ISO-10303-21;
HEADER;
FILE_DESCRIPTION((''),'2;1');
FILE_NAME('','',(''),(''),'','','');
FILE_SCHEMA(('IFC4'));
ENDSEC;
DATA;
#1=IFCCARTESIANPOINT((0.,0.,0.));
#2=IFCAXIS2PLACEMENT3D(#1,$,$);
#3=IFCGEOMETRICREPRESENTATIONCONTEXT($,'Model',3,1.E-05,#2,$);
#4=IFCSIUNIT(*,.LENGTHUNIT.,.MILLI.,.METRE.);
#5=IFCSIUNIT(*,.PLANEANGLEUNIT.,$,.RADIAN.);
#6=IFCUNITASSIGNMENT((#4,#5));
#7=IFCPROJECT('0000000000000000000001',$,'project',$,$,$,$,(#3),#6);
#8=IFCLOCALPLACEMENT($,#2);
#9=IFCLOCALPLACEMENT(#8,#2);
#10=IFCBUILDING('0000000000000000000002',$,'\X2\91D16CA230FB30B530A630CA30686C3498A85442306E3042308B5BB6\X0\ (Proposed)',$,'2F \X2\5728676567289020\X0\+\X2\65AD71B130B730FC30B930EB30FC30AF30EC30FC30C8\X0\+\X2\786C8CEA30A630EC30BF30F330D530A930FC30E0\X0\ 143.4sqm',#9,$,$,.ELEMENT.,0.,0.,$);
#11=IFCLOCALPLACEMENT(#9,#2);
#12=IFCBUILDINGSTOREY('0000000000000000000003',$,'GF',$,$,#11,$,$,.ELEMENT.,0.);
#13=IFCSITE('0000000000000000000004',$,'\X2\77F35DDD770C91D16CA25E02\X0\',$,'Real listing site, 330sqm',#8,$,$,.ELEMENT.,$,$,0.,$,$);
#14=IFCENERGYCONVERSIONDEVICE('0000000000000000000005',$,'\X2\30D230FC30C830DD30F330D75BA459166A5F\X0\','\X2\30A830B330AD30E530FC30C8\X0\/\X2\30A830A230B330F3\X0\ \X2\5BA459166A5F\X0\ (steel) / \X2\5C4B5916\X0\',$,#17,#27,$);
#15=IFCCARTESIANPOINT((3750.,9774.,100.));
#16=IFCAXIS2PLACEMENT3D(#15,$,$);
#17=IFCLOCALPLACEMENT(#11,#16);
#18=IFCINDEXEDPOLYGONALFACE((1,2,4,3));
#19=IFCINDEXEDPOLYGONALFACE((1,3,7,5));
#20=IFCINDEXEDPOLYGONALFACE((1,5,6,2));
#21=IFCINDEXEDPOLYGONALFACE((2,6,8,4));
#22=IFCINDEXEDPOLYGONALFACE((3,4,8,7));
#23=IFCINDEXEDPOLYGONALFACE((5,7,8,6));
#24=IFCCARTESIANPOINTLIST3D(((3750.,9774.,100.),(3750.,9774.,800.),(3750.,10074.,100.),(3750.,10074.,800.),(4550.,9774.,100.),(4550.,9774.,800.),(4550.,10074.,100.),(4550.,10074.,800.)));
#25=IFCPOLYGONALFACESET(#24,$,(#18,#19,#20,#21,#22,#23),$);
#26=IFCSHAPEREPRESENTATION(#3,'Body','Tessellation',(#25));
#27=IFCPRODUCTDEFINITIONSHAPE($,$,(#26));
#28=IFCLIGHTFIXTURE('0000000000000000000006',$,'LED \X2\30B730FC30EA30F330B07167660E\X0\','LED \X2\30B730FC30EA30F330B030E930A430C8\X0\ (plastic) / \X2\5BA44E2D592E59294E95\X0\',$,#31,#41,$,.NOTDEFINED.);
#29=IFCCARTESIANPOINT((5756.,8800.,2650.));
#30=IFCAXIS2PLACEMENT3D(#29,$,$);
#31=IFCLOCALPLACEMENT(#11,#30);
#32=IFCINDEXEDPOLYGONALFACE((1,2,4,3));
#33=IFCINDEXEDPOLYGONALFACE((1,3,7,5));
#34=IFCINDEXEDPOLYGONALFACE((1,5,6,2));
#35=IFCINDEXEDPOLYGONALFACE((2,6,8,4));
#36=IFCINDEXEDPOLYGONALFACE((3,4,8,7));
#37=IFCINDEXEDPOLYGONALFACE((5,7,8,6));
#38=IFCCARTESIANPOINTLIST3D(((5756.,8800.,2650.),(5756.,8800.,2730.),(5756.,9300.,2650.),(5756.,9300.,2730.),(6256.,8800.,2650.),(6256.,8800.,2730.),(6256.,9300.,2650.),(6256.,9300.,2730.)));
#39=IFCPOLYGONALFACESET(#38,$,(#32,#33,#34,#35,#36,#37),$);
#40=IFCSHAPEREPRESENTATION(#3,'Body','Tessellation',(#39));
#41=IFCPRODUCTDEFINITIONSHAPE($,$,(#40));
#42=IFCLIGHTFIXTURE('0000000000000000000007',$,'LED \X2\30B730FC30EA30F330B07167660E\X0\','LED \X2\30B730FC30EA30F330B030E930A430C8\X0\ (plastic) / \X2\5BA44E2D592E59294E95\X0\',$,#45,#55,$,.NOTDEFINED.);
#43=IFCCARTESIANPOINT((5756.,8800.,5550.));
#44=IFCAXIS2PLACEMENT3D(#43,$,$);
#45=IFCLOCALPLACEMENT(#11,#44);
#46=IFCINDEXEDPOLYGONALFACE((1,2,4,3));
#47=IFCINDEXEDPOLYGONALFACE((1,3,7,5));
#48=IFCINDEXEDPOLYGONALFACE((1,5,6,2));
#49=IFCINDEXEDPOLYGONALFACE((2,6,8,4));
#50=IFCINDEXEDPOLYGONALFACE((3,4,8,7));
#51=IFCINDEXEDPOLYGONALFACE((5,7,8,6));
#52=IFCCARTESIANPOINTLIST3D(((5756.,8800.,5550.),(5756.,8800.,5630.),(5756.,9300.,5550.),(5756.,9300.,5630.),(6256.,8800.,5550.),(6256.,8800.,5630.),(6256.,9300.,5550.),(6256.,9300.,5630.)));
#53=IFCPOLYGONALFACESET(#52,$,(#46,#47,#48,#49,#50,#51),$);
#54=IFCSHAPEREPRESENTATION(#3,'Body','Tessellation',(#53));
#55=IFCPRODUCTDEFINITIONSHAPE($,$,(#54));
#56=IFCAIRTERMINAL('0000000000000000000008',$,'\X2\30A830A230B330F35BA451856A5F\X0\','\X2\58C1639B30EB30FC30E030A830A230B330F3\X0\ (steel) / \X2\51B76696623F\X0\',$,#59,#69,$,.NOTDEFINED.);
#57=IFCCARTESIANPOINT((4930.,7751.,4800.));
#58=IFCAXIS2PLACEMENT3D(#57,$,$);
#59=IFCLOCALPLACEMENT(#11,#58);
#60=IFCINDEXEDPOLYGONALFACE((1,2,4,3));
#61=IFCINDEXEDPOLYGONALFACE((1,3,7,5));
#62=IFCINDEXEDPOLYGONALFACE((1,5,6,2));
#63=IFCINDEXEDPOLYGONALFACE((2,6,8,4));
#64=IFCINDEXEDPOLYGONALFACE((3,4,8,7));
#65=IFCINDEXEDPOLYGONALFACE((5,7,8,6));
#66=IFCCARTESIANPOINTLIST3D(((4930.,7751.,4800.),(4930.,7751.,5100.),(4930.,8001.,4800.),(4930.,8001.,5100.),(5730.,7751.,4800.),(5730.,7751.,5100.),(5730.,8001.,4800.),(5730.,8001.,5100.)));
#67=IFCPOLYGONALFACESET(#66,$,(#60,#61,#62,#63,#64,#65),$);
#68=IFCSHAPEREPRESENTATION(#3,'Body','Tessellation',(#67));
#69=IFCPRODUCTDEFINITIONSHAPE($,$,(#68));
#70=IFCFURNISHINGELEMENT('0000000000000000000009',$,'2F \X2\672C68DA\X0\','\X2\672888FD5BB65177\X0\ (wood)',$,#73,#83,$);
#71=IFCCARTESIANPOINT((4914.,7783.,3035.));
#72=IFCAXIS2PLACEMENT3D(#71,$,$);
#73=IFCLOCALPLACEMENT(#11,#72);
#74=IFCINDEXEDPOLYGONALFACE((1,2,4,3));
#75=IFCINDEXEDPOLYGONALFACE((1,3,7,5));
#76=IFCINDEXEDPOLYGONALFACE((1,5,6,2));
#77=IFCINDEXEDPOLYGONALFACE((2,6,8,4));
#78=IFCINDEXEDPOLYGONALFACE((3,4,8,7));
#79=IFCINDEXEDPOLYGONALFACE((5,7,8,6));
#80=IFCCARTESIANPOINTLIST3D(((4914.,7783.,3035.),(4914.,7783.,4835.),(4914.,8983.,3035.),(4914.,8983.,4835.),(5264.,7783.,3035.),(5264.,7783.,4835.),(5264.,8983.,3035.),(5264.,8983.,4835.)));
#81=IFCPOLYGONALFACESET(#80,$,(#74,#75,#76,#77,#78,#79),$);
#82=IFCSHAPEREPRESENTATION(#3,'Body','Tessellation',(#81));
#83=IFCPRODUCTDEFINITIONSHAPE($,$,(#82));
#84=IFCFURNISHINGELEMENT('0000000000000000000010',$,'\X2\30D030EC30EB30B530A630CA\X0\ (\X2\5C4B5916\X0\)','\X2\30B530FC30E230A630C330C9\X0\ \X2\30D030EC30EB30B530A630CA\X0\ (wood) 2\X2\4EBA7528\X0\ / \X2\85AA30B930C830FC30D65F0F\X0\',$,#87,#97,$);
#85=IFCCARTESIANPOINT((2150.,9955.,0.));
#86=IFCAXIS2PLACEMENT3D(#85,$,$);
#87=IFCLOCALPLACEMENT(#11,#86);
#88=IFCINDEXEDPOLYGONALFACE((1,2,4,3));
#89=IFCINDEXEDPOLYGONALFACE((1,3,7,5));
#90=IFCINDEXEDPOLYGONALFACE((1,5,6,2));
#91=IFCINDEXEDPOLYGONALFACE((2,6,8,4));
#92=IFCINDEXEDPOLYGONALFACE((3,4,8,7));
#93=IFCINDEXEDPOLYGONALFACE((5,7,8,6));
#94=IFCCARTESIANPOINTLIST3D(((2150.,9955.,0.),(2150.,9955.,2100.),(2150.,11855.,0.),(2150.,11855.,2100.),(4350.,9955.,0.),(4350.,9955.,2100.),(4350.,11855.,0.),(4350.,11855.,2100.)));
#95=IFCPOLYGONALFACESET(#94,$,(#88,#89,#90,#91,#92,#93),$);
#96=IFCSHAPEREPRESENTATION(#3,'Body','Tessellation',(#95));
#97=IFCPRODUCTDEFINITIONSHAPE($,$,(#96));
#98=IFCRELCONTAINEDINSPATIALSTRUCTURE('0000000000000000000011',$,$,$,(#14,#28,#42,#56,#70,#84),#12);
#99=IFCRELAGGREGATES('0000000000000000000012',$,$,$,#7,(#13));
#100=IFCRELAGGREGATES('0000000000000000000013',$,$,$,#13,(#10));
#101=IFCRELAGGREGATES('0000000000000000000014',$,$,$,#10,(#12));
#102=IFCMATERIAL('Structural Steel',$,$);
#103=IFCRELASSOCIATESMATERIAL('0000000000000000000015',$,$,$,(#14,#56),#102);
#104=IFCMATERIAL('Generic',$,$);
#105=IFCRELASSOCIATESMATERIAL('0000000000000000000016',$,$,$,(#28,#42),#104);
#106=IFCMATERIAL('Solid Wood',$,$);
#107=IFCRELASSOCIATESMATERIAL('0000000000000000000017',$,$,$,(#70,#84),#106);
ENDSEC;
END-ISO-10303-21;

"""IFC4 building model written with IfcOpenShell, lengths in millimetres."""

from ifc_helpers import new_model, si_unit, frame, frame_2d, origin, place, context, project, spatial, rectangle, extrude, material, element, save


model = new_model("IFC4")

# Units and contexts
model_context = context("Model", 3, precision=1e-05, world=origin())
ifc_project = project(units=[si_unit("LENGTHUNIT", "METRE", prefix="MILLI"), si_unit("PLANEANGLEUNIT", "RADIAN")], contexts=[model_context])

# Site, building, storey
site_placement = place(None, origin())
site = spatial("IfcSite", under=ifc_project, at=site_placement, Name="石川県金沢市", ObjectType="Real listing site, 330sqm", CompositionType="ELEMENT", RefElevation=0.0)
building_placement = place(site_placement, origin())
building = spatial("IfcBuilding", under=site, at=building_placement, Name="金沢・サウナと水風呂のある家 (Proposed)", ObjectType="2F 在来木造+断熱シースルークレート+硬質ウレタンフォーム 143.4sqm", CompositionType="ELEMENT", ElevationOfRefHeight=0.0, ElevationOfTerrain=0.0)
storey_placement = place(building_placement, origin())
storey = spatial("IfcBuildingStorey", under=building, at=storey_placement, Name="GF", CompositionType="ELEMENT", Elevation=0.0)

# Shared definitions
ifc_material_1 = material(Name="Solid Wood")

# Shared definitions
ifc_material_2 = material(Name="Structural Steel")

# Shared definitions
ifc_material_3 = material(Name="Generic")

# Energy conversion device
energy_conversion_device_placement = place(storey_placement, frame((3750.0, 9774.0, 100.0)))
element("IfcEnergyConversionDevice", 1, at=energy_conversion_device_placement, inside=storey, material=ifc_material_2, Name="ヒートポンプ室外機", Description="エコキュート/エアコン 室外機 (steel) / 屋外", context=model_context, shape_type="SweptSolid", body=[
    extrude(rectangle(XDim=800.0, YDim=300.0, at=frame_2d((400.0, 150.0))), frame((3750.0, 9774.0, 100.0)), (0.0, 0.0, 1.0), 700.0),
])

# Light fixtures
light_fixture_1_placement = place(storey_placement, frame((5756.0, 8800.0, 2650.0)))
element("IfcLightFixture", 2, at=light_fixture_1_placement, inside=storey, material=ifc_material_3, Name="LED シーリング照明", Description="LED シーリングライト (plastic) / 室中央天井", PredefinedType="NOTDEFINED", context=model_context, shape_type="SweptSolid", body=[
    extrude(rectangle(XDim=500.0, YDim=500.0, at=frame_2d((250.0, 250.0))), frame((5756.0, 8800.0, 2650.0)), (0.0, 0.0, 1.0), 80.0),
])
light_fixture_2_placement = place(storey_placement, frame((5756.0, 8800.0, 5550.0)))
element("IfcLightFixture", 3, at=light_fixture_2_placement, inside=storey, material=ifc_material_3, Name="LED シーリング照明", Description="LED シーリングライト (plastic) / 室中央天井", PredefinedType="NOTDEFINED", context=model_context, shape_type="SweptSolid", body=[
    extrude(rectangle(XDim=500.0, YDim=500.0, at=frame_2d((250.0, 250.0))), frame((5756.0, 8800.0, 5550.0)), (0.0, 0.0, 1.0), 80.0),
])

# Air terminal
air_terminal_placement = place(storey_placement, frame((4930.0, 7751.0, 4800.0)))
element("IfcAirTerminal", 4, at=air_terminal_placement, inside=storey, material=ifc_material_2, Name="エアコン室内機", Description="壁掛ルームエアコン (steel) / 冷暖房", PredefinedType="NOTDEFINED", context=model_context, shape_type="SweptSolid", body=[
    extrude(rectangle(XDim=800.0, YDim=250.0, at=frame_2d((400.0, 125.0))), frame((4930.0, 7751.0, 4800.0)), (0.0, 0.0, 1.0), 300.0),
])

# Furnishing elements
furnishing_1_placement = place(storey_placement, frame((4914.0, 7783.0, 3035.0)))
element("IfcFurnishingElement", 5, at=furnishing_1_placement, inside=storey, material=ifc_material_1, Name="2F 本棚", Description="木製家具 (wood)", context=model_context, shape_type="SweptSolid", body=[
    extrude(rectangle(XDim=350.0, YDim=1200.0, at=frame_2d((175.0, 600.0))), frame((4914.0, 7783.0, 3035.0)), (0.0, 0.0, 1.0), 1800.0),
])
furnishing_2_placement = place(storey_placement, frame((2150.0, 9955.0, 0.0)))
element("IfcFurnishingElement", 6, at=furnishing_2_placement, inside=storey, material=ifc_material_1, Name="バレルサウナ (屋外)", Description="サーモウッド バレルサウナ (wood) 2人用 / 薪ストーブ式", context=model_context, shape_type="SweptSolid", body=[
    extrude(rectangle(XDim=2200.0, YDim=1900.0, at=frame_2d((1100.0, 950.0))), frame((2150.0, 9955.0, 0.0)), (0.0, 0.0, 1.0), 2100.0),
])

save(model, "model.ifc")
